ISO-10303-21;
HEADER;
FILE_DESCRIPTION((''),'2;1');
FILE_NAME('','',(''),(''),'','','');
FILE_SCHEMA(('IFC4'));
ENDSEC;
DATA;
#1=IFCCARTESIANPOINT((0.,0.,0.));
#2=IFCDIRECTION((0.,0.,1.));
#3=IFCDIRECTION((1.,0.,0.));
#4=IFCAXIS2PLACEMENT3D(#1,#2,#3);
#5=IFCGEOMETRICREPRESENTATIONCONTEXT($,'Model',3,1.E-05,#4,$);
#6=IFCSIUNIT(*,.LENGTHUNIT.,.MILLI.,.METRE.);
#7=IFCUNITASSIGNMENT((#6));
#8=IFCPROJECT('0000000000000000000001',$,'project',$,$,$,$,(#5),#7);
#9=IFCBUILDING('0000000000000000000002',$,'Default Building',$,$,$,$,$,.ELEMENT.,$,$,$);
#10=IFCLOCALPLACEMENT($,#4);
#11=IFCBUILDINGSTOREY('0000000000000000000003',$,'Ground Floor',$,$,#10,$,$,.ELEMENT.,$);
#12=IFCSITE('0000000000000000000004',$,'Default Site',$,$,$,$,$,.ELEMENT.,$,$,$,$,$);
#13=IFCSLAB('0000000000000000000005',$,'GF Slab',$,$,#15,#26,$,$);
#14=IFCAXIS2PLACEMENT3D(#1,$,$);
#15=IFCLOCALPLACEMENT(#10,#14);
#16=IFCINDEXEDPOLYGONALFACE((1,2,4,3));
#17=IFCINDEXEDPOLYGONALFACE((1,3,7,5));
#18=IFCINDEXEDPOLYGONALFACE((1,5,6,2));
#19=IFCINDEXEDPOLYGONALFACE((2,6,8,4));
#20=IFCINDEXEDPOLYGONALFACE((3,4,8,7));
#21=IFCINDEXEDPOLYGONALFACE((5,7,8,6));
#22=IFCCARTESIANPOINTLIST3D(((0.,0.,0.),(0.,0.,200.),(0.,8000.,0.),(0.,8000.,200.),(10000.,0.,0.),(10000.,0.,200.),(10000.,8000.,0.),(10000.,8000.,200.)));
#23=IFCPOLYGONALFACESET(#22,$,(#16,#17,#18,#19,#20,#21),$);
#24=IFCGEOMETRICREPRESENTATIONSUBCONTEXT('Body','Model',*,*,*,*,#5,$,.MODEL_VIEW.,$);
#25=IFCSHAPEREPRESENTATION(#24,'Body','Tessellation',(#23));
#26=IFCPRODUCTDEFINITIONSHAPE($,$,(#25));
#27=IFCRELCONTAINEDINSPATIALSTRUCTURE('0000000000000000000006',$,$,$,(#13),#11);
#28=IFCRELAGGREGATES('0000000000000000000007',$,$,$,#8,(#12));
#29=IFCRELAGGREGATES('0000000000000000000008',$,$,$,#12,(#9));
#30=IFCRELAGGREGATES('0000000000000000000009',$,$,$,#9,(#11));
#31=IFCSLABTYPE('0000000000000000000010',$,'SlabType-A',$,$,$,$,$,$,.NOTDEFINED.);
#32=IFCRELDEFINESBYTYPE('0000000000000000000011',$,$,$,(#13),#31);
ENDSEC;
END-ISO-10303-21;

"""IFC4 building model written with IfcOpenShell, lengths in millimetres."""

from ifc_helpers import new_model, si_unit, origin_with_axes, place, context, subcontext, project, spatial, polyline, outline, extrude, type_object, element, save


model = new_model("IFC4")

# Units and contexts
model_context = context("Model", 3, precision=1e-05, world=origin_with_axes())
body_context = subcontext(model_context, "Body", "Model", "MODEL_VIEW")
ifc_project = project(units=[si_unit("LENGTHUNIT", "METRE", prefix="MILLI")], contexts=[model_context])

# Site, building, storey
site = spatial("IfcSite", under=ifc_project, Name="Default Site", CompositionType="ELEMENT")
building = spatial("IfcBuilding", under=site, Name="Default Building", CompositionType="ELEMENT")
storey_placement = place(None, origin_with_axes())
storey = spatial("IfcBuildingStorey", under=building, at=storey_placement, Name="Ground Floor", CompositionType="ELEMENT")

# Slab
slab_type = type_object("IfcSlabType", Name="SlabType-A", PredefinedType="NOTDEFINED")
slab_placement = place(storey_placement, origin_with_axes())
element("IfcSlab", 1, at=slab_placement, inside=storey, type_object=slab_type, Name="GF Slab", context=body_context, shape_type="SweptSolid", body=[
    extrude(outline(polyline([(0.0, 0.0), (10000.0, 0.0), (10000.0, 8000.0), (0.0, 8000.0), (0.0, 0.0)])), origin_with_axes(), (0.0, 0.0, 1.0), 200.0),
])

save(model, "model.ifc")
